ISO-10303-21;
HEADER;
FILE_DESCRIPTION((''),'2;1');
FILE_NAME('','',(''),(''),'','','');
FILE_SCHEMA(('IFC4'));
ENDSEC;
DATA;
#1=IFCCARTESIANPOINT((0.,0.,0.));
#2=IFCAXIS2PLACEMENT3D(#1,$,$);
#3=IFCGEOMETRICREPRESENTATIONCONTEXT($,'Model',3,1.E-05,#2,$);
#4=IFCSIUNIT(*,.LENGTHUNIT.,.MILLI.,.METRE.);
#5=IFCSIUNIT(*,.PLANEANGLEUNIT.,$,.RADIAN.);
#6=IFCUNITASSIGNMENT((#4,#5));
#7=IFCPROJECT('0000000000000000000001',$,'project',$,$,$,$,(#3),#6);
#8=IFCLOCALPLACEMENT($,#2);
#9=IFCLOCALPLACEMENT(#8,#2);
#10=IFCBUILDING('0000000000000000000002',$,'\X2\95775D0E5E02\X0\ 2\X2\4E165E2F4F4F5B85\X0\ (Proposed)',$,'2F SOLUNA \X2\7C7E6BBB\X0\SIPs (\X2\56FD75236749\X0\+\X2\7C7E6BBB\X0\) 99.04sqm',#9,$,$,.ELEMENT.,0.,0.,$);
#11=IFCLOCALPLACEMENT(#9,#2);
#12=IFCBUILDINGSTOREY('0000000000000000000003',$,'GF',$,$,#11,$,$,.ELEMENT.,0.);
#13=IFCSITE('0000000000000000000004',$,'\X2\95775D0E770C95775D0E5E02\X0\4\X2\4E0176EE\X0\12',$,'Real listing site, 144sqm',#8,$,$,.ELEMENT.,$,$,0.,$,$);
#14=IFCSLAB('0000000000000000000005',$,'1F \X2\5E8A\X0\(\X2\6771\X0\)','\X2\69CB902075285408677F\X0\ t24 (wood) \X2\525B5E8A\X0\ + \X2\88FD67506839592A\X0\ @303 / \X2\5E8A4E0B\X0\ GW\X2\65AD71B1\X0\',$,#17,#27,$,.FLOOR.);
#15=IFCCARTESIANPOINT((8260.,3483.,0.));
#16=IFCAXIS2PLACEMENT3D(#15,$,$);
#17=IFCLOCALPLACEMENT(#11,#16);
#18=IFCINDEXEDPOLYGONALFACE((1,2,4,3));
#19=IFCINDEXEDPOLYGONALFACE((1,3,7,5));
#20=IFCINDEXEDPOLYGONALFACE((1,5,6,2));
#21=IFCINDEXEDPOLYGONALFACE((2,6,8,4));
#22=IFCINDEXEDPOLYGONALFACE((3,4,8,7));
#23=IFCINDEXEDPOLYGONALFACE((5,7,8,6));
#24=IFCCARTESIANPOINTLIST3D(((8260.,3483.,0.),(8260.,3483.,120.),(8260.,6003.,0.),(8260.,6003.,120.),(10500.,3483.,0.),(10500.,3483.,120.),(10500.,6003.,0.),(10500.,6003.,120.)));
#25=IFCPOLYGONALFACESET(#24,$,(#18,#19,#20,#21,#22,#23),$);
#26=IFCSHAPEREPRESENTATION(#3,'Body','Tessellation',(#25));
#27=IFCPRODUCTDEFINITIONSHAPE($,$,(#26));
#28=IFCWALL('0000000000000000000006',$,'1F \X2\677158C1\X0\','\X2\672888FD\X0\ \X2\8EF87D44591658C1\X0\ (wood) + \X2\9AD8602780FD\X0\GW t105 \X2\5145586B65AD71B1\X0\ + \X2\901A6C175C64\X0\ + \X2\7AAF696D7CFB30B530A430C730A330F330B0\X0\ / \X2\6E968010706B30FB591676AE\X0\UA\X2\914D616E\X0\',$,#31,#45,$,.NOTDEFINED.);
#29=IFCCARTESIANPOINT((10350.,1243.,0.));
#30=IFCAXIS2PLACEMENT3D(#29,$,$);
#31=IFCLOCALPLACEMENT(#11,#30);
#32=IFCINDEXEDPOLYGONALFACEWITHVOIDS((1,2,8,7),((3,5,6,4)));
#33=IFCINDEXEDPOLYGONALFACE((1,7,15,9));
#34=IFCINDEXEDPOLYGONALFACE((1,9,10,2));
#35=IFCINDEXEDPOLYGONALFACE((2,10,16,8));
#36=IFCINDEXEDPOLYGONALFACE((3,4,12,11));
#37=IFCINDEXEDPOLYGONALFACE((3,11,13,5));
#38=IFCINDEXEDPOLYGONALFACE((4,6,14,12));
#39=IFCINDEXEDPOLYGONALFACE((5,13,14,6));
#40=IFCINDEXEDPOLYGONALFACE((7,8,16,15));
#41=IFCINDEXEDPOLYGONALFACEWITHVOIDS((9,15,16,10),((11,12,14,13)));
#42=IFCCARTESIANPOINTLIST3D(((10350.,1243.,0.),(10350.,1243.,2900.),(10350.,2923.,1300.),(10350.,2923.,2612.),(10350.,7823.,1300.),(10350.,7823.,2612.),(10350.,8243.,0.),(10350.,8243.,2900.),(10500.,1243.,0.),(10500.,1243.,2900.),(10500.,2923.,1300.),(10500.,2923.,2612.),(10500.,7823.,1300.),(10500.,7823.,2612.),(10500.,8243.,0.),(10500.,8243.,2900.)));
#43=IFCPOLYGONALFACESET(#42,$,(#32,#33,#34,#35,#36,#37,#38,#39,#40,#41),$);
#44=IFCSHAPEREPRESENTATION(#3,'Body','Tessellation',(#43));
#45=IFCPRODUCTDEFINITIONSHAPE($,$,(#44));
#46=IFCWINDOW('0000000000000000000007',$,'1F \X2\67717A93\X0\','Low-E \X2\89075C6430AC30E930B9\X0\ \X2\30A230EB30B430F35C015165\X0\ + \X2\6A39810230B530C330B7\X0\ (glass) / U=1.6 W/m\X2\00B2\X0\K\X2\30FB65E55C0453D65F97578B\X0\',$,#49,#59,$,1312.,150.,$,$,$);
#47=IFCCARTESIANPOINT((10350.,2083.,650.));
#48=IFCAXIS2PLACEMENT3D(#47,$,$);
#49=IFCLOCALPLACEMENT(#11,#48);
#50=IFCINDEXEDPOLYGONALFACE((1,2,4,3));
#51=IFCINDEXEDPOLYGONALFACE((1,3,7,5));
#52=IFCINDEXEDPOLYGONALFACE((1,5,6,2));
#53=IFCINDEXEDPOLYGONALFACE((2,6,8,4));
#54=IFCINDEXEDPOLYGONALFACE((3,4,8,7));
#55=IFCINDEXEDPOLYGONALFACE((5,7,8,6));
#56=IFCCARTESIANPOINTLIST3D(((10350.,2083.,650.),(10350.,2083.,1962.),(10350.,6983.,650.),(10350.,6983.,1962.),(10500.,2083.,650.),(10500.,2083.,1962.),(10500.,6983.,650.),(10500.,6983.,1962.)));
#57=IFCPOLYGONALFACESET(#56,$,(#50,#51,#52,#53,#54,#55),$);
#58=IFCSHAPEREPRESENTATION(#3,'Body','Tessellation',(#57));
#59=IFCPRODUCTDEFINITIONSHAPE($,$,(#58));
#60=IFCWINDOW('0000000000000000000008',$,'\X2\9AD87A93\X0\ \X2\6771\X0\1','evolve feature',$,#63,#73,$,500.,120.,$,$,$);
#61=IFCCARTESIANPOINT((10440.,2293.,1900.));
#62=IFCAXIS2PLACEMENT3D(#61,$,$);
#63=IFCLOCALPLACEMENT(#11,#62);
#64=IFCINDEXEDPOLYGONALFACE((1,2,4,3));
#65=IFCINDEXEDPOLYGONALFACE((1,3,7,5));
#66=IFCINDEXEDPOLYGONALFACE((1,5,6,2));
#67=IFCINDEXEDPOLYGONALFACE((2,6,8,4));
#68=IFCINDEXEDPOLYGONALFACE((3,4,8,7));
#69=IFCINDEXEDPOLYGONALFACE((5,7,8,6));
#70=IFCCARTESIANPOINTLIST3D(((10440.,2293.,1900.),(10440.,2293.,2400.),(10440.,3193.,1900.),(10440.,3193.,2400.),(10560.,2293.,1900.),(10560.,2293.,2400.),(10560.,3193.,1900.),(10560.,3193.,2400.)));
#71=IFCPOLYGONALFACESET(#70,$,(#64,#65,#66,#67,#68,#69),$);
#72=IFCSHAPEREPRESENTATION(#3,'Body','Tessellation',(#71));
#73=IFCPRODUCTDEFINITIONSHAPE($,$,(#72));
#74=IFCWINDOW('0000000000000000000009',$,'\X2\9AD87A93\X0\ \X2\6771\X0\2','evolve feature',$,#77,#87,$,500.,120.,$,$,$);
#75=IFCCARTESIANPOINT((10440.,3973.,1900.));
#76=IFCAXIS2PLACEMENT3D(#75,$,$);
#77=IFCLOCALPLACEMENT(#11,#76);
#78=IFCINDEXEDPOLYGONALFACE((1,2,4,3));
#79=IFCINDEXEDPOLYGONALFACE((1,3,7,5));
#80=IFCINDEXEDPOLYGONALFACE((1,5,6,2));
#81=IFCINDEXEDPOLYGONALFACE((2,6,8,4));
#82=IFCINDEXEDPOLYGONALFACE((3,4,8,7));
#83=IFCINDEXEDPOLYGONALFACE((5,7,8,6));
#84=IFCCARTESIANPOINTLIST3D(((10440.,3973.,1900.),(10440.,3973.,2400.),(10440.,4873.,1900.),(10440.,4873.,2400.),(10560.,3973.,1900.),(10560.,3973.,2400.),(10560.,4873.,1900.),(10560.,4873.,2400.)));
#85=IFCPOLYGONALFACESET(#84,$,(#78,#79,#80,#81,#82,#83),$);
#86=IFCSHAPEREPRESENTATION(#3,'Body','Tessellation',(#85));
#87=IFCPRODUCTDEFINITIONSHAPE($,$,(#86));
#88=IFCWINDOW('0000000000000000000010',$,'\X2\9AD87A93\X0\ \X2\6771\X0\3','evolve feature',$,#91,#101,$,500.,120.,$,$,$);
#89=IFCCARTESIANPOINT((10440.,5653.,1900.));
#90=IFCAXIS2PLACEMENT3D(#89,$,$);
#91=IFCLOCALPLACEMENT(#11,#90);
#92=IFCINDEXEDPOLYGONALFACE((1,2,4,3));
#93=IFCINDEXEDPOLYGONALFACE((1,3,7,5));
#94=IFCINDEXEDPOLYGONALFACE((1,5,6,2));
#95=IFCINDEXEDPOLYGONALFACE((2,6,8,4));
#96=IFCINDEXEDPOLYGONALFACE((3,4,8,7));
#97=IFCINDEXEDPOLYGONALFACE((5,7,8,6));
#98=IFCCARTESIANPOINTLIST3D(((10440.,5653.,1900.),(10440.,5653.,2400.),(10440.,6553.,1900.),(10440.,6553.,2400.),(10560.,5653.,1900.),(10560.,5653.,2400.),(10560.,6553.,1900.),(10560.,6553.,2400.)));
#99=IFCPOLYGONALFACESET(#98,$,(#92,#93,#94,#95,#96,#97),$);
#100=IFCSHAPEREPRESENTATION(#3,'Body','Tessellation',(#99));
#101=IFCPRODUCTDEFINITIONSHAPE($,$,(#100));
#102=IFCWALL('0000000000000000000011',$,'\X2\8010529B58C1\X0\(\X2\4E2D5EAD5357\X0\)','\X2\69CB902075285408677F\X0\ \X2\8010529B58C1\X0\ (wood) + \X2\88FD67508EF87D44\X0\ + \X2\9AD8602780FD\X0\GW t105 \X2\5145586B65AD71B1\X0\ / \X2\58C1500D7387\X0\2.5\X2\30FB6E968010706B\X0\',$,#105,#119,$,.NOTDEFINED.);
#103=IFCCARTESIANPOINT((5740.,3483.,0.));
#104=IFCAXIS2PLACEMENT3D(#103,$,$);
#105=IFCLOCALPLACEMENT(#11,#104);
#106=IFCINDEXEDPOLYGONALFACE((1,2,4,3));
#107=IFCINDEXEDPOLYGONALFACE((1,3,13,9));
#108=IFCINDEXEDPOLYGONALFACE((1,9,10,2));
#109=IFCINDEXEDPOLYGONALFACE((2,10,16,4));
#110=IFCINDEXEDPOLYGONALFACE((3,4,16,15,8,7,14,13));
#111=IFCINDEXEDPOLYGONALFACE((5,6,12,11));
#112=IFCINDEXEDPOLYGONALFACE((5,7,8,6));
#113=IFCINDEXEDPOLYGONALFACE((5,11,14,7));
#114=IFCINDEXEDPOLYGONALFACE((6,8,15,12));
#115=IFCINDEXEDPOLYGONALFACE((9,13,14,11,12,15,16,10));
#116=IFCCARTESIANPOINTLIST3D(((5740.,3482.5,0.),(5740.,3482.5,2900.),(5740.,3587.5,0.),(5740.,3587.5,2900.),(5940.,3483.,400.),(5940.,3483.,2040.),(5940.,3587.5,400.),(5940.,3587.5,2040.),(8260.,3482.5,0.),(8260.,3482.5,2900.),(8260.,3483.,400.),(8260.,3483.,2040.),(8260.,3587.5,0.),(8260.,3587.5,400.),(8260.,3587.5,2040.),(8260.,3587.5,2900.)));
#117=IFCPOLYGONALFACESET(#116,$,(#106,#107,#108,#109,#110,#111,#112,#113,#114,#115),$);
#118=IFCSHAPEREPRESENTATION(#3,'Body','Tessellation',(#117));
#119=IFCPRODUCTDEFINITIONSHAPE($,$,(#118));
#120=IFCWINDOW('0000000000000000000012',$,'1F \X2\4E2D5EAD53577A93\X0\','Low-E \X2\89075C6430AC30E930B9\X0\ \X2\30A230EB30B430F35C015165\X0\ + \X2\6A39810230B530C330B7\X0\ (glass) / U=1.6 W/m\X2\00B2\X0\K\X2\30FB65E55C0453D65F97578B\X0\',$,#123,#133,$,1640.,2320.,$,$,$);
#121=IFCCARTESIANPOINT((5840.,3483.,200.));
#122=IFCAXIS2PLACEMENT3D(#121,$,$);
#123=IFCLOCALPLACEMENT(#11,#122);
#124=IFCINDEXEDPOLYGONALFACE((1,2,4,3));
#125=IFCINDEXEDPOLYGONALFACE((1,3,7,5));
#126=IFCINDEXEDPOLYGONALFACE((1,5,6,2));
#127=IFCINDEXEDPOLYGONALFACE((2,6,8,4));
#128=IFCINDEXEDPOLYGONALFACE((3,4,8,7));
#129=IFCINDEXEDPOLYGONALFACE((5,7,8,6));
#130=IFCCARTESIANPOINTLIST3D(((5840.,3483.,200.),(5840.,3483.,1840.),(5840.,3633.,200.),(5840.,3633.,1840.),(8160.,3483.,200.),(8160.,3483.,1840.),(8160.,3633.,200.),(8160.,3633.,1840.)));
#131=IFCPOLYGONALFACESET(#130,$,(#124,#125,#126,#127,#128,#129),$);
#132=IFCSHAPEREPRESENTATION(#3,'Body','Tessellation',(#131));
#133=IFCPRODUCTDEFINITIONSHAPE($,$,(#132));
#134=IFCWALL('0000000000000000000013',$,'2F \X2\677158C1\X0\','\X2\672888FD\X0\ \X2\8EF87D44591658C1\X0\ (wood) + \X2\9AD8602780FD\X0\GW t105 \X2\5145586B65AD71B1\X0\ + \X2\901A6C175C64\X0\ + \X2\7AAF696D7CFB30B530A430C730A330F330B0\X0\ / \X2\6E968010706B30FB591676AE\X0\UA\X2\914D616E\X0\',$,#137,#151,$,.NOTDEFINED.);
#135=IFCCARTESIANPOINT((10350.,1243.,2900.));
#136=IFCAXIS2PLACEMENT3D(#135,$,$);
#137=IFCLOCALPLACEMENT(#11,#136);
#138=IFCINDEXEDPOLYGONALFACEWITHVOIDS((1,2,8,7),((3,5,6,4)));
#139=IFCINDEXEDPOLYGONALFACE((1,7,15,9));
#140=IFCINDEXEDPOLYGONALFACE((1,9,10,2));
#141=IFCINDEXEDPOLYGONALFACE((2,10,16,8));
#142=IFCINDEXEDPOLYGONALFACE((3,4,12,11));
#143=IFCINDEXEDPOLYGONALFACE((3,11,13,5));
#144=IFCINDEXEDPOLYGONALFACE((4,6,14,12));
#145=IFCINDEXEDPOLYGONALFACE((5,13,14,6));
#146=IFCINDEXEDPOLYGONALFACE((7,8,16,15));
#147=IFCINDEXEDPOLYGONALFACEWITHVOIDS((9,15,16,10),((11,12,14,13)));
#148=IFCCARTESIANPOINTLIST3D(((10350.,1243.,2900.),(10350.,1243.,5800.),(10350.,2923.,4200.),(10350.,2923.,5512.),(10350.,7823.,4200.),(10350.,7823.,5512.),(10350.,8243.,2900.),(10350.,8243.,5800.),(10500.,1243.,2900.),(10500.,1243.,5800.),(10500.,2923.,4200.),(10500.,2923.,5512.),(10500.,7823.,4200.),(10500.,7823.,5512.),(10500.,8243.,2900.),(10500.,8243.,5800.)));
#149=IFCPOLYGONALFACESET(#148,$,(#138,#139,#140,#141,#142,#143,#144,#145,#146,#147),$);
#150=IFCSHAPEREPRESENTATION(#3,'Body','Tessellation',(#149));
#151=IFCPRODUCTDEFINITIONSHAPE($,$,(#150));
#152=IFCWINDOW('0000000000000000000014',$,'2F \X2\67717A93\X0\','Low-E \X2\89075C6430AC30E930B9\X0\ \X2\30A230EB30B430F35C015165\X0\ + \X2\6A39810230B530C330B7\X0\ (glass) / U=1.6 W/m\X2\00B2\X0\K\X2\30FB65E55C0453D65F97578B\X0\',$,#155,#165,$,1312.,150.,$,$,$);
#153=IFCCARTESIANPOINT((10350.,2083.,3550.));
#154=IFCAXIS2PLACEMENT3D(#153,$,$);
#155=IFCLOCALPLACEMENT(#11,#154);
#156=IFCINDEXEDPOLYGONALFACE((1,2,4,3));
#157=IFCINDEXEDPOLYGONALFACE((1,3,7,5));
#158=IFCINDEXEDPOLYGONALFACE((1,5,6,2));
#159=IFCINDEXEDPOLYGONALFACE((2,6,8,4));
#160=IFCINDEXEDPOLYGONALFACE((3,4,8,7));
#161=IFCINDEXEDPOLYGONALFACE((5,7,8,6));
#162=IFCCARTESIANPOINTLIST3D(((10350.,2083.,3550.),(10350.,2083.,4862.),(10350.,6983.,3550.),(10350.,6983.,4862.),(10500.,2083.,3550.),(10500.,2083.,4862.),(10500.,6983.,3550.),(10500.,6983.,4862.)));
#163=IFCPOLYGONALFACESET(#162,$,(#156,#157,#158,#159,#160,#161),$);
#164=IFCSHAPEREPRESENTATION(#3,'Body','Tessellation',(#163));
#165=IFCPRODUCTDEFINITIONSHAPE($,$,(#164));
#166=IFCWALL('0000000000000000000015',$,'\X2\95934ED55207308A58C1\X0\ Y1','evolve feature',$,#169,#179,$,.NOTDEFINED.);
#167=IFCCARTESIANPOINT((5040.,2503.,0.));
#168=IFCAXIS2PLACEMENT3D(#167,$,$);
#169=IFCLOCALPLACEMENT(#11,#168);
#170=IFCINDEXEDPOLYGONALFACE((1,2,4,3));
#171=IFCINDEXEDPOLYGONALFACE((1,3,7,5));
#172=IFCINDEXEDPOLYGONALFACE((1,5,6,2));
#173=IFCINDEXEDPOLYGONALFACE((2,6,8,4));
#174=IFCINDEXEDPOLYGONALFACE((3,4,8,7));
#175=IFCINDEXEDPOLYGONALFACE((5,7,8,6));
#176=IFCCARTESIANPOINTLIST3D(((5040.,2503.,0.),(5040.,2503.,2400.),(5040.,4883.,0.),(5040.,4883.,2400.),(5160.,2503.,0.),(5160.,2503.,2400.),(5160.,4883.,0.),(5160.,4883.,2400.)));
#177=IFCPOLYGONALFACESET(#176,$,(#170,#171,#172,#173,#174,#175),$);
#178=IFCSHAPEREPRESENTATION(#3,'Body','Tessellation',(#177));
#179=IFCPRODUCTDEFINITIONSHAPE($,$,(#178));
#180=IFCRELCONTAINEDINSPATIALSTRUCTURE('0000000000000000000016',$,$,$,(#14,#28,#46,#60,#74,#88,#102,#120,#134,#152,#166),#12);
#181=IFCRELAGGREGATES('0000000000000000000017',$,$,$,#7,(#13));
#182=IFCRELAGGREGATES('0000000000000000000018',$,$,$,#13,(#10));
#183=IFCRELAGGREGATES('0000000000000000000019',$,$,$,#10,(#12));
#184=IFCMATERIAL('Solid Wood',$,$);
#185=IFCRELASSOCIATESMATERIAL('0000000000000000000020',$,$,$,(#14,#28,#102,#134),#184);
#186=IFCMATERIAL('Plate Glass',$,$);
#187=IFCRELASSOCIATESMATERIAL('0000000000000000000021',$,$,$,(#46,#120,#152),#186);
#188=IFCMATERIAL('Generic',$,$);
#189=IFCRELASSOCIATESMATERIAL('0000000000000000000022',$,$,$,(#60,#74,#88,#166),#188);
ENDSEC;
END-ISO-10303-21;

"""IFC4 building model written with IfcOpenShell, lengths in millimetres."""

from ifc_helpers import new_model, si_unit, frame, frame_2d, origin, place, context, project, spatial, rectangle, extrude, material, element, fill, save


model = new_model("IFC4")

# Units and contexts
model_context = context("Model", 3, precision=1e-05, world=origin())
ifc_project = project(units=[si_unit("LENGTHUNIT", "METRE", prefix="MILLI"), si_unit("PLANEANGLEUNIT", "RADIAN")], contexts=[model_context])

# Site, building, storey
site_placement = place(None, origin())
site = spatial("IfcSite", under=ifc_project, at=site_placement, Name="長崎県長崎市4丁目12", ObjectType="Real listing site, 144sqm", CompositionType="ELEMENT", RefElevation=0.0)
building_placement = place(site_placement, origin())
building = spatial("IfcBuilding", under=site, at=building_placement, Name="長崎市 2世帯住宅 (Proposed)", ObjectType="2F SOLUNA 籾殻SIPs (国産杉+籾殻) 99.04sqm", CompositionType="ELEMENT", ElevationOfRefHeight=0.0, ElevationOfTerrain=0.0)
storey_placement = place(building_placement, origin())
storey = spatial("IfcBuildingStorey", under=building, at=storey_placement, Name="GF", CompositionType="ELEMENT", Elevation=0.0)

# Slab
ifc_material_1 = material(Name="Solid Wood")
slab_placement = place(storey_placement, frame((8260.0, 3483.0, 0.0)))
element("IfcSlab", 1, at=slab_placement, inside=storey, material=ifc_material_1, Name="1F 床(東)", Description="構造用合板 t24 (wood) 剛床 + 製材根太 @303 / 床下 GW断熱", PredefinedType="FLOOR", context=model_context, shape_type="SweptSolid", body=[
    extrude(rectangle(XDim=2240.0, YDim=2520.0, at=frame_2d((1120.0, 1260.0))), frame((8260.0, 3483.0, 0.0)), (0.0, 0.0, 1.0), 120.0),
])

# Wall, openings, windows
wall_1_placement = place(storey_placement, frame((10350.0, 1243.0, 0.0)))
wall_1 = element("IfcWall", 2, at=wall_1_placement, inside=storey, material=ifc_material_1, Name="1F 東壁", Description="木製 軸組外壁 (wood) + 高性能GW t105 充填断熱 + 通気層 + 窯業系サイディング / 準耐火・外皮UA配慮", PredefinedType="NOTDEFINED", context=model_context, shape_type="SweptSolid", body=[
    extrude(rectangle(XDim=150.0, YDim=7000.0, at=frame_2d((75.0, 3500.0))), frame((10350.0, 1243.0, 0.0)), (0.0, 0.0, 1.0), 2900.0),
])
opening_1_placement = place(storey_placement, frame((10350.0, 2083.0, 650.0)))
opening_1 = element("IfcOpeningElement", 3, at=opening_1_placement, cuts=wall_1, PredefinedType="NOTDEFINED", context=model_context, shape_type="SweptSolid", body=[
    extrude(rectangle(XDim=150.0, YDim=4900.0, at=frame_2d((75.0, 2450.0))), frame((10350.0, 2083.0, 650.0)), (0.0, 0.0, 1.0), 1312.0),
])
opening_2_placement = place(storey_placement, frame((10440.0, 2293.0, 1900.0)))
opening_2 = element("IfcOpeningElement", 4, at=opening_2_placement, cuts=wall_1, PredefinedType="NOTDEFINED", context=model_context, shape_type="SweptSolid", body=[
    extrude(rectangle(XDim=120.0, YDim=900.0, at=frame_2d((60.0, 450.0))), frame((10440.0, 2293.0, 1900.0)), (0.0, 0.0, 1.0), 500.0),
])
opening_3_placement = place(storey_placement, frame((10440.0, 3973.0, 1900.0)))
opening_3 = element("IfcOpeningElement", 5, at=opening_3_placement, cuts=wall_1, PredefinedType="NOTDEFINED", context=model_context, shape_type="SweptSolid", body=[
    extrude(rectangle(XDim=120.0, YDim=900.0, at=frame_2d((60.0, 450.0))), frame((10440.0, 3973.0, 1900.0)), (0.0, 0.0, 1.0), 500.0),
])
opening_4_placement = place(storey_placement, frame((10440.0, 5653.0, 1900.0)))
opening_4 = element("IfcOpeningElement", 6, at=opening_4_placement, cuts=wall_1, PredefinedType="NOTDEFINED", context=model_context, shape_type="SweptSolid", body=[
    extrude(rectangle(XDim=120.0, YDim=900.0, at=frame_2d((60.0, 450.0))), frame((10440.0, 5653.0, 1900.0)), (0.0, 0.0, 1.0), 500.0),
])
ifc_material_2 = material(Name="Plate Glass")
window_1_placement = place(storey_placement, frame((10350.0, 2083.0, 650.0)))
window_1 = element("IfcWindow", 7, at=window_1_placement, inside=storey, material=ifc_material_2, Name="1F 東窓", Description="Low-E 複層ガラス アルゴン封入 + 樹脂サッシ (glass) / U=1.6 W/m²K・日射取得型", OverallHeight=1312.0, OverallWidth=150.0, context=model_context, shape_type="SweptSolid", body=[
    extrude(rectangle(XDim=150.0, YDim=4900.0, at=frame_2d((75.0, 2450.0))), frame((10350.0, 2083.0, 650.0)), (0.0, 0.0, 1.0), 1312.0),
])
fill(opening_1, window_1)
ifc_material_3 = material(Name="Generic")
window_2_placement = place(storey_placement, frame((10440.0, 2293.0, 1900.0)))
window_2 = element("IfcWindow", 8, at=window_2_placement, inside=storey, material=ifc_material_3, Name="高窓 東1", Description="evolve feature", OverallHeight=500.0, OverallWidth=120.0, context=model_context, shape_type="SweptSolid", body=[
    extrude(rectangle(XDim=120.0, YDim=900.0, at=frame_2d((60.0, 450.0))), frame((10440.0, 2293.0, 1900.0)), (0.0, 0.0, 1.0), 500.0),
])
fill(opening_2, window_2)
window_3_placement = place(storey_placement, frame((10440.0, 3973.0, 1900.0)))
window_3 = element("IfcWindow", 9, at=window_3_placement, inside=storey, material=ifc_material_3, Name="高窓 東2", Description="evolve feature", OverallHeight=500.0, OverallWidth=120.0, context=model_context, shape_type="SweptSolid", body=[
    extrude(rectangle(XDim=120.0, YDim=900.0, at=frame_2d((60.0, 450.0))), frame((10440.0, 3973.0, 1900.0)), (0.0, 0.0, 1.0), 500.0),
])
fill(opening_3, window_3)
window_4_placement = place(storey_placement, frame((10440.0, 5653.0, 1900.0)))
window_4 = element("IfcWindow", 10, at=window_4_placement, inside=storey, material=ifc_material_3, Name="高窓 東3", Description="evolve feature", OverallHeight=500.0, OverallWidth=120.0, context=model_context, shape_type="SweptSolid", body=[
    extrude(rectangle(XDim=120.0, YDim=900.0, at=frame_2d((60.0, 450.0))), frame((10440.0, 5653.0, 1900.0)), (0.0, 0.0, 1.0), 500.0),
])
fill(opening_4, window_4)

# Wall, opening, window
wall_2_placement = place(storey_placement, frame((5740.0, 3483.0, 0.0)))
wall_2 = element("IfcWall", 11, at=wall_2_placement, inside=storey, material=ifc_material_1, Name="耐力壁(中庭南)", Description="構造用合板 耐力壁 (wood) + 製材軸組 + 高性能GW t105 充填断熱 / 壁倍率2.5・準耐火", PredefinedType="NOTDEFINED", context=model_context, shape_type="SweptSolid", body=[
    extrude(rectangle(XDim=2520.0, YDim=105.0, at=frame_2d((1260.0, 52.0))), frame((5740.0, 3483.0, 0.0)), (0.0, 0.0, 1.0), 2900.0),
])
opening_5_placement = place(storey_placement, frame((5840.0, 3483.0, 200.0)))
opening_5 = element("IfcOpeningElement", 12, at=opening_5_placement, cuts=wall_2, PredefinedType="NOTDEFINED", context=model_context, shape_type="SweptSolid", body=[
    extrude(rectangle(XDim=2320.0, YDim=150.0, at=frame_2d((1160.0, 75.0))), frame((5840.0, 3483.0, 200.0)), (0.0, 0.0, 1.0), 1640.0),
])
window_5_placement = place(storey_placement, frame((5840.0, 3483.0, 200.0)))
window_5 = element("IfcWindow", 13, at=window_5_placement, inside=storey, material=ifc_material_2, Name="1F 中庭南窓", Description="Low-E 複層ガラス アルゴン封入 + 樹脂サッシ (glass) / U=1.6 W/m²K・日射取得型", OverallHeight=1640.0, OverallWidth=2320.0, context=model_context, shape_type="SweptSolid", body=[
    extrude(rectangle(XDim=2320.0, YDim=150.0, at=frame_2d((1160.0, 75.0))), frame((5840.0, 3483.0, 200.0)), (0.0, 0.0, 1.0), 1640.0),
])
fill(opening_5, window_5)

# Wall, opening, window
wall_3_placement = place(storey_placement, frame((10350.0, 1243.0, 2900.0)))
wall_3 = element("IfcWall", 14, at=wall_3_placement, inside=storey, material=ifc_material_1, Name="2F 東壁", Description="木製 軸組外壁 (wood) + 高性能GW t105 充填断熱 + 通気層 + 窯業系サイディング / 準耐火・外皮UA配慮", PredefinedType="NOTDEFINED", context=model_context, shape_type="SweptSolid", body=[
    extrude(rectangle(XDim=150.0, YDim=7000.0, at=frame_2d((75.0, 3500.0))), frame((10350.0, 1243.0, 2900.0)), (0.0, 0.0, 1.0), 2900.0),
])
opening_6_placement = place(storey_placement, frame((10350.0, 2083.0, 3550.0)))
opening_6 = element("IfcOpeningElement", 15, at=opening_6_placement, cuts=wall_3, PredefinedType="NOTDEFINED", context=model_context, shape_type="SweptSolid", body=[
    extrude(rectangle(XDim=150.0, YDim=4900.0, at=frame_2d((75.0, 2450.0))), frame((10350.0, 2083.0, 3550.0)), (0.0, 0.0, 1.0), 1312.0),
])
window_6_placement = place(storey_placement, frame((10350.0, 2083.0, 3550.0)))
window_6 = element("IfcWindow", 16, at=window_6_placement, inside=storey, material=ifc_material_2, Name="2F 東窓", Description="Low-E 複層ガラス アルゴン封入 + 樹脂サッシ (glass) / U=1.6 W/m²K・日射取得型", OverallHeight=1312.0, OverallWidth=150.0, context=model_context, shape_type="SweptSolid", body=[
    extrude(rectangle(XDim=150.0, YDim=4900.0, at=frame_2d((75.0, 2450.0))), frame((10350.0, 2083.0, 3550.0)), (0.0, 0.0, 1.0), 1312.0),
])
fill(opening_6, window_6)

# Wall
wall_4_placement = place(storey_placement, frame((5040.0, 2503.0, 0.0)))
element("IfcWall", 17, at=wall_4_placement, inside=storey, material=ifc_material_3, Name="間仕切り壁 Y1", Description="evolve feature", PredefinedType="NOTDEFINED", context=model_context, shape_type="SweptSolid", body=[
    extrude(rectangle(XDim=120.0, YDim=2380.0, at=frame_2d((60.0, 1190.0))), frame((5040.0, 2503.0, 0.0)), (0.0, 0.0, 1.0), 2400.0),
])

save(model, "model.ifc")
